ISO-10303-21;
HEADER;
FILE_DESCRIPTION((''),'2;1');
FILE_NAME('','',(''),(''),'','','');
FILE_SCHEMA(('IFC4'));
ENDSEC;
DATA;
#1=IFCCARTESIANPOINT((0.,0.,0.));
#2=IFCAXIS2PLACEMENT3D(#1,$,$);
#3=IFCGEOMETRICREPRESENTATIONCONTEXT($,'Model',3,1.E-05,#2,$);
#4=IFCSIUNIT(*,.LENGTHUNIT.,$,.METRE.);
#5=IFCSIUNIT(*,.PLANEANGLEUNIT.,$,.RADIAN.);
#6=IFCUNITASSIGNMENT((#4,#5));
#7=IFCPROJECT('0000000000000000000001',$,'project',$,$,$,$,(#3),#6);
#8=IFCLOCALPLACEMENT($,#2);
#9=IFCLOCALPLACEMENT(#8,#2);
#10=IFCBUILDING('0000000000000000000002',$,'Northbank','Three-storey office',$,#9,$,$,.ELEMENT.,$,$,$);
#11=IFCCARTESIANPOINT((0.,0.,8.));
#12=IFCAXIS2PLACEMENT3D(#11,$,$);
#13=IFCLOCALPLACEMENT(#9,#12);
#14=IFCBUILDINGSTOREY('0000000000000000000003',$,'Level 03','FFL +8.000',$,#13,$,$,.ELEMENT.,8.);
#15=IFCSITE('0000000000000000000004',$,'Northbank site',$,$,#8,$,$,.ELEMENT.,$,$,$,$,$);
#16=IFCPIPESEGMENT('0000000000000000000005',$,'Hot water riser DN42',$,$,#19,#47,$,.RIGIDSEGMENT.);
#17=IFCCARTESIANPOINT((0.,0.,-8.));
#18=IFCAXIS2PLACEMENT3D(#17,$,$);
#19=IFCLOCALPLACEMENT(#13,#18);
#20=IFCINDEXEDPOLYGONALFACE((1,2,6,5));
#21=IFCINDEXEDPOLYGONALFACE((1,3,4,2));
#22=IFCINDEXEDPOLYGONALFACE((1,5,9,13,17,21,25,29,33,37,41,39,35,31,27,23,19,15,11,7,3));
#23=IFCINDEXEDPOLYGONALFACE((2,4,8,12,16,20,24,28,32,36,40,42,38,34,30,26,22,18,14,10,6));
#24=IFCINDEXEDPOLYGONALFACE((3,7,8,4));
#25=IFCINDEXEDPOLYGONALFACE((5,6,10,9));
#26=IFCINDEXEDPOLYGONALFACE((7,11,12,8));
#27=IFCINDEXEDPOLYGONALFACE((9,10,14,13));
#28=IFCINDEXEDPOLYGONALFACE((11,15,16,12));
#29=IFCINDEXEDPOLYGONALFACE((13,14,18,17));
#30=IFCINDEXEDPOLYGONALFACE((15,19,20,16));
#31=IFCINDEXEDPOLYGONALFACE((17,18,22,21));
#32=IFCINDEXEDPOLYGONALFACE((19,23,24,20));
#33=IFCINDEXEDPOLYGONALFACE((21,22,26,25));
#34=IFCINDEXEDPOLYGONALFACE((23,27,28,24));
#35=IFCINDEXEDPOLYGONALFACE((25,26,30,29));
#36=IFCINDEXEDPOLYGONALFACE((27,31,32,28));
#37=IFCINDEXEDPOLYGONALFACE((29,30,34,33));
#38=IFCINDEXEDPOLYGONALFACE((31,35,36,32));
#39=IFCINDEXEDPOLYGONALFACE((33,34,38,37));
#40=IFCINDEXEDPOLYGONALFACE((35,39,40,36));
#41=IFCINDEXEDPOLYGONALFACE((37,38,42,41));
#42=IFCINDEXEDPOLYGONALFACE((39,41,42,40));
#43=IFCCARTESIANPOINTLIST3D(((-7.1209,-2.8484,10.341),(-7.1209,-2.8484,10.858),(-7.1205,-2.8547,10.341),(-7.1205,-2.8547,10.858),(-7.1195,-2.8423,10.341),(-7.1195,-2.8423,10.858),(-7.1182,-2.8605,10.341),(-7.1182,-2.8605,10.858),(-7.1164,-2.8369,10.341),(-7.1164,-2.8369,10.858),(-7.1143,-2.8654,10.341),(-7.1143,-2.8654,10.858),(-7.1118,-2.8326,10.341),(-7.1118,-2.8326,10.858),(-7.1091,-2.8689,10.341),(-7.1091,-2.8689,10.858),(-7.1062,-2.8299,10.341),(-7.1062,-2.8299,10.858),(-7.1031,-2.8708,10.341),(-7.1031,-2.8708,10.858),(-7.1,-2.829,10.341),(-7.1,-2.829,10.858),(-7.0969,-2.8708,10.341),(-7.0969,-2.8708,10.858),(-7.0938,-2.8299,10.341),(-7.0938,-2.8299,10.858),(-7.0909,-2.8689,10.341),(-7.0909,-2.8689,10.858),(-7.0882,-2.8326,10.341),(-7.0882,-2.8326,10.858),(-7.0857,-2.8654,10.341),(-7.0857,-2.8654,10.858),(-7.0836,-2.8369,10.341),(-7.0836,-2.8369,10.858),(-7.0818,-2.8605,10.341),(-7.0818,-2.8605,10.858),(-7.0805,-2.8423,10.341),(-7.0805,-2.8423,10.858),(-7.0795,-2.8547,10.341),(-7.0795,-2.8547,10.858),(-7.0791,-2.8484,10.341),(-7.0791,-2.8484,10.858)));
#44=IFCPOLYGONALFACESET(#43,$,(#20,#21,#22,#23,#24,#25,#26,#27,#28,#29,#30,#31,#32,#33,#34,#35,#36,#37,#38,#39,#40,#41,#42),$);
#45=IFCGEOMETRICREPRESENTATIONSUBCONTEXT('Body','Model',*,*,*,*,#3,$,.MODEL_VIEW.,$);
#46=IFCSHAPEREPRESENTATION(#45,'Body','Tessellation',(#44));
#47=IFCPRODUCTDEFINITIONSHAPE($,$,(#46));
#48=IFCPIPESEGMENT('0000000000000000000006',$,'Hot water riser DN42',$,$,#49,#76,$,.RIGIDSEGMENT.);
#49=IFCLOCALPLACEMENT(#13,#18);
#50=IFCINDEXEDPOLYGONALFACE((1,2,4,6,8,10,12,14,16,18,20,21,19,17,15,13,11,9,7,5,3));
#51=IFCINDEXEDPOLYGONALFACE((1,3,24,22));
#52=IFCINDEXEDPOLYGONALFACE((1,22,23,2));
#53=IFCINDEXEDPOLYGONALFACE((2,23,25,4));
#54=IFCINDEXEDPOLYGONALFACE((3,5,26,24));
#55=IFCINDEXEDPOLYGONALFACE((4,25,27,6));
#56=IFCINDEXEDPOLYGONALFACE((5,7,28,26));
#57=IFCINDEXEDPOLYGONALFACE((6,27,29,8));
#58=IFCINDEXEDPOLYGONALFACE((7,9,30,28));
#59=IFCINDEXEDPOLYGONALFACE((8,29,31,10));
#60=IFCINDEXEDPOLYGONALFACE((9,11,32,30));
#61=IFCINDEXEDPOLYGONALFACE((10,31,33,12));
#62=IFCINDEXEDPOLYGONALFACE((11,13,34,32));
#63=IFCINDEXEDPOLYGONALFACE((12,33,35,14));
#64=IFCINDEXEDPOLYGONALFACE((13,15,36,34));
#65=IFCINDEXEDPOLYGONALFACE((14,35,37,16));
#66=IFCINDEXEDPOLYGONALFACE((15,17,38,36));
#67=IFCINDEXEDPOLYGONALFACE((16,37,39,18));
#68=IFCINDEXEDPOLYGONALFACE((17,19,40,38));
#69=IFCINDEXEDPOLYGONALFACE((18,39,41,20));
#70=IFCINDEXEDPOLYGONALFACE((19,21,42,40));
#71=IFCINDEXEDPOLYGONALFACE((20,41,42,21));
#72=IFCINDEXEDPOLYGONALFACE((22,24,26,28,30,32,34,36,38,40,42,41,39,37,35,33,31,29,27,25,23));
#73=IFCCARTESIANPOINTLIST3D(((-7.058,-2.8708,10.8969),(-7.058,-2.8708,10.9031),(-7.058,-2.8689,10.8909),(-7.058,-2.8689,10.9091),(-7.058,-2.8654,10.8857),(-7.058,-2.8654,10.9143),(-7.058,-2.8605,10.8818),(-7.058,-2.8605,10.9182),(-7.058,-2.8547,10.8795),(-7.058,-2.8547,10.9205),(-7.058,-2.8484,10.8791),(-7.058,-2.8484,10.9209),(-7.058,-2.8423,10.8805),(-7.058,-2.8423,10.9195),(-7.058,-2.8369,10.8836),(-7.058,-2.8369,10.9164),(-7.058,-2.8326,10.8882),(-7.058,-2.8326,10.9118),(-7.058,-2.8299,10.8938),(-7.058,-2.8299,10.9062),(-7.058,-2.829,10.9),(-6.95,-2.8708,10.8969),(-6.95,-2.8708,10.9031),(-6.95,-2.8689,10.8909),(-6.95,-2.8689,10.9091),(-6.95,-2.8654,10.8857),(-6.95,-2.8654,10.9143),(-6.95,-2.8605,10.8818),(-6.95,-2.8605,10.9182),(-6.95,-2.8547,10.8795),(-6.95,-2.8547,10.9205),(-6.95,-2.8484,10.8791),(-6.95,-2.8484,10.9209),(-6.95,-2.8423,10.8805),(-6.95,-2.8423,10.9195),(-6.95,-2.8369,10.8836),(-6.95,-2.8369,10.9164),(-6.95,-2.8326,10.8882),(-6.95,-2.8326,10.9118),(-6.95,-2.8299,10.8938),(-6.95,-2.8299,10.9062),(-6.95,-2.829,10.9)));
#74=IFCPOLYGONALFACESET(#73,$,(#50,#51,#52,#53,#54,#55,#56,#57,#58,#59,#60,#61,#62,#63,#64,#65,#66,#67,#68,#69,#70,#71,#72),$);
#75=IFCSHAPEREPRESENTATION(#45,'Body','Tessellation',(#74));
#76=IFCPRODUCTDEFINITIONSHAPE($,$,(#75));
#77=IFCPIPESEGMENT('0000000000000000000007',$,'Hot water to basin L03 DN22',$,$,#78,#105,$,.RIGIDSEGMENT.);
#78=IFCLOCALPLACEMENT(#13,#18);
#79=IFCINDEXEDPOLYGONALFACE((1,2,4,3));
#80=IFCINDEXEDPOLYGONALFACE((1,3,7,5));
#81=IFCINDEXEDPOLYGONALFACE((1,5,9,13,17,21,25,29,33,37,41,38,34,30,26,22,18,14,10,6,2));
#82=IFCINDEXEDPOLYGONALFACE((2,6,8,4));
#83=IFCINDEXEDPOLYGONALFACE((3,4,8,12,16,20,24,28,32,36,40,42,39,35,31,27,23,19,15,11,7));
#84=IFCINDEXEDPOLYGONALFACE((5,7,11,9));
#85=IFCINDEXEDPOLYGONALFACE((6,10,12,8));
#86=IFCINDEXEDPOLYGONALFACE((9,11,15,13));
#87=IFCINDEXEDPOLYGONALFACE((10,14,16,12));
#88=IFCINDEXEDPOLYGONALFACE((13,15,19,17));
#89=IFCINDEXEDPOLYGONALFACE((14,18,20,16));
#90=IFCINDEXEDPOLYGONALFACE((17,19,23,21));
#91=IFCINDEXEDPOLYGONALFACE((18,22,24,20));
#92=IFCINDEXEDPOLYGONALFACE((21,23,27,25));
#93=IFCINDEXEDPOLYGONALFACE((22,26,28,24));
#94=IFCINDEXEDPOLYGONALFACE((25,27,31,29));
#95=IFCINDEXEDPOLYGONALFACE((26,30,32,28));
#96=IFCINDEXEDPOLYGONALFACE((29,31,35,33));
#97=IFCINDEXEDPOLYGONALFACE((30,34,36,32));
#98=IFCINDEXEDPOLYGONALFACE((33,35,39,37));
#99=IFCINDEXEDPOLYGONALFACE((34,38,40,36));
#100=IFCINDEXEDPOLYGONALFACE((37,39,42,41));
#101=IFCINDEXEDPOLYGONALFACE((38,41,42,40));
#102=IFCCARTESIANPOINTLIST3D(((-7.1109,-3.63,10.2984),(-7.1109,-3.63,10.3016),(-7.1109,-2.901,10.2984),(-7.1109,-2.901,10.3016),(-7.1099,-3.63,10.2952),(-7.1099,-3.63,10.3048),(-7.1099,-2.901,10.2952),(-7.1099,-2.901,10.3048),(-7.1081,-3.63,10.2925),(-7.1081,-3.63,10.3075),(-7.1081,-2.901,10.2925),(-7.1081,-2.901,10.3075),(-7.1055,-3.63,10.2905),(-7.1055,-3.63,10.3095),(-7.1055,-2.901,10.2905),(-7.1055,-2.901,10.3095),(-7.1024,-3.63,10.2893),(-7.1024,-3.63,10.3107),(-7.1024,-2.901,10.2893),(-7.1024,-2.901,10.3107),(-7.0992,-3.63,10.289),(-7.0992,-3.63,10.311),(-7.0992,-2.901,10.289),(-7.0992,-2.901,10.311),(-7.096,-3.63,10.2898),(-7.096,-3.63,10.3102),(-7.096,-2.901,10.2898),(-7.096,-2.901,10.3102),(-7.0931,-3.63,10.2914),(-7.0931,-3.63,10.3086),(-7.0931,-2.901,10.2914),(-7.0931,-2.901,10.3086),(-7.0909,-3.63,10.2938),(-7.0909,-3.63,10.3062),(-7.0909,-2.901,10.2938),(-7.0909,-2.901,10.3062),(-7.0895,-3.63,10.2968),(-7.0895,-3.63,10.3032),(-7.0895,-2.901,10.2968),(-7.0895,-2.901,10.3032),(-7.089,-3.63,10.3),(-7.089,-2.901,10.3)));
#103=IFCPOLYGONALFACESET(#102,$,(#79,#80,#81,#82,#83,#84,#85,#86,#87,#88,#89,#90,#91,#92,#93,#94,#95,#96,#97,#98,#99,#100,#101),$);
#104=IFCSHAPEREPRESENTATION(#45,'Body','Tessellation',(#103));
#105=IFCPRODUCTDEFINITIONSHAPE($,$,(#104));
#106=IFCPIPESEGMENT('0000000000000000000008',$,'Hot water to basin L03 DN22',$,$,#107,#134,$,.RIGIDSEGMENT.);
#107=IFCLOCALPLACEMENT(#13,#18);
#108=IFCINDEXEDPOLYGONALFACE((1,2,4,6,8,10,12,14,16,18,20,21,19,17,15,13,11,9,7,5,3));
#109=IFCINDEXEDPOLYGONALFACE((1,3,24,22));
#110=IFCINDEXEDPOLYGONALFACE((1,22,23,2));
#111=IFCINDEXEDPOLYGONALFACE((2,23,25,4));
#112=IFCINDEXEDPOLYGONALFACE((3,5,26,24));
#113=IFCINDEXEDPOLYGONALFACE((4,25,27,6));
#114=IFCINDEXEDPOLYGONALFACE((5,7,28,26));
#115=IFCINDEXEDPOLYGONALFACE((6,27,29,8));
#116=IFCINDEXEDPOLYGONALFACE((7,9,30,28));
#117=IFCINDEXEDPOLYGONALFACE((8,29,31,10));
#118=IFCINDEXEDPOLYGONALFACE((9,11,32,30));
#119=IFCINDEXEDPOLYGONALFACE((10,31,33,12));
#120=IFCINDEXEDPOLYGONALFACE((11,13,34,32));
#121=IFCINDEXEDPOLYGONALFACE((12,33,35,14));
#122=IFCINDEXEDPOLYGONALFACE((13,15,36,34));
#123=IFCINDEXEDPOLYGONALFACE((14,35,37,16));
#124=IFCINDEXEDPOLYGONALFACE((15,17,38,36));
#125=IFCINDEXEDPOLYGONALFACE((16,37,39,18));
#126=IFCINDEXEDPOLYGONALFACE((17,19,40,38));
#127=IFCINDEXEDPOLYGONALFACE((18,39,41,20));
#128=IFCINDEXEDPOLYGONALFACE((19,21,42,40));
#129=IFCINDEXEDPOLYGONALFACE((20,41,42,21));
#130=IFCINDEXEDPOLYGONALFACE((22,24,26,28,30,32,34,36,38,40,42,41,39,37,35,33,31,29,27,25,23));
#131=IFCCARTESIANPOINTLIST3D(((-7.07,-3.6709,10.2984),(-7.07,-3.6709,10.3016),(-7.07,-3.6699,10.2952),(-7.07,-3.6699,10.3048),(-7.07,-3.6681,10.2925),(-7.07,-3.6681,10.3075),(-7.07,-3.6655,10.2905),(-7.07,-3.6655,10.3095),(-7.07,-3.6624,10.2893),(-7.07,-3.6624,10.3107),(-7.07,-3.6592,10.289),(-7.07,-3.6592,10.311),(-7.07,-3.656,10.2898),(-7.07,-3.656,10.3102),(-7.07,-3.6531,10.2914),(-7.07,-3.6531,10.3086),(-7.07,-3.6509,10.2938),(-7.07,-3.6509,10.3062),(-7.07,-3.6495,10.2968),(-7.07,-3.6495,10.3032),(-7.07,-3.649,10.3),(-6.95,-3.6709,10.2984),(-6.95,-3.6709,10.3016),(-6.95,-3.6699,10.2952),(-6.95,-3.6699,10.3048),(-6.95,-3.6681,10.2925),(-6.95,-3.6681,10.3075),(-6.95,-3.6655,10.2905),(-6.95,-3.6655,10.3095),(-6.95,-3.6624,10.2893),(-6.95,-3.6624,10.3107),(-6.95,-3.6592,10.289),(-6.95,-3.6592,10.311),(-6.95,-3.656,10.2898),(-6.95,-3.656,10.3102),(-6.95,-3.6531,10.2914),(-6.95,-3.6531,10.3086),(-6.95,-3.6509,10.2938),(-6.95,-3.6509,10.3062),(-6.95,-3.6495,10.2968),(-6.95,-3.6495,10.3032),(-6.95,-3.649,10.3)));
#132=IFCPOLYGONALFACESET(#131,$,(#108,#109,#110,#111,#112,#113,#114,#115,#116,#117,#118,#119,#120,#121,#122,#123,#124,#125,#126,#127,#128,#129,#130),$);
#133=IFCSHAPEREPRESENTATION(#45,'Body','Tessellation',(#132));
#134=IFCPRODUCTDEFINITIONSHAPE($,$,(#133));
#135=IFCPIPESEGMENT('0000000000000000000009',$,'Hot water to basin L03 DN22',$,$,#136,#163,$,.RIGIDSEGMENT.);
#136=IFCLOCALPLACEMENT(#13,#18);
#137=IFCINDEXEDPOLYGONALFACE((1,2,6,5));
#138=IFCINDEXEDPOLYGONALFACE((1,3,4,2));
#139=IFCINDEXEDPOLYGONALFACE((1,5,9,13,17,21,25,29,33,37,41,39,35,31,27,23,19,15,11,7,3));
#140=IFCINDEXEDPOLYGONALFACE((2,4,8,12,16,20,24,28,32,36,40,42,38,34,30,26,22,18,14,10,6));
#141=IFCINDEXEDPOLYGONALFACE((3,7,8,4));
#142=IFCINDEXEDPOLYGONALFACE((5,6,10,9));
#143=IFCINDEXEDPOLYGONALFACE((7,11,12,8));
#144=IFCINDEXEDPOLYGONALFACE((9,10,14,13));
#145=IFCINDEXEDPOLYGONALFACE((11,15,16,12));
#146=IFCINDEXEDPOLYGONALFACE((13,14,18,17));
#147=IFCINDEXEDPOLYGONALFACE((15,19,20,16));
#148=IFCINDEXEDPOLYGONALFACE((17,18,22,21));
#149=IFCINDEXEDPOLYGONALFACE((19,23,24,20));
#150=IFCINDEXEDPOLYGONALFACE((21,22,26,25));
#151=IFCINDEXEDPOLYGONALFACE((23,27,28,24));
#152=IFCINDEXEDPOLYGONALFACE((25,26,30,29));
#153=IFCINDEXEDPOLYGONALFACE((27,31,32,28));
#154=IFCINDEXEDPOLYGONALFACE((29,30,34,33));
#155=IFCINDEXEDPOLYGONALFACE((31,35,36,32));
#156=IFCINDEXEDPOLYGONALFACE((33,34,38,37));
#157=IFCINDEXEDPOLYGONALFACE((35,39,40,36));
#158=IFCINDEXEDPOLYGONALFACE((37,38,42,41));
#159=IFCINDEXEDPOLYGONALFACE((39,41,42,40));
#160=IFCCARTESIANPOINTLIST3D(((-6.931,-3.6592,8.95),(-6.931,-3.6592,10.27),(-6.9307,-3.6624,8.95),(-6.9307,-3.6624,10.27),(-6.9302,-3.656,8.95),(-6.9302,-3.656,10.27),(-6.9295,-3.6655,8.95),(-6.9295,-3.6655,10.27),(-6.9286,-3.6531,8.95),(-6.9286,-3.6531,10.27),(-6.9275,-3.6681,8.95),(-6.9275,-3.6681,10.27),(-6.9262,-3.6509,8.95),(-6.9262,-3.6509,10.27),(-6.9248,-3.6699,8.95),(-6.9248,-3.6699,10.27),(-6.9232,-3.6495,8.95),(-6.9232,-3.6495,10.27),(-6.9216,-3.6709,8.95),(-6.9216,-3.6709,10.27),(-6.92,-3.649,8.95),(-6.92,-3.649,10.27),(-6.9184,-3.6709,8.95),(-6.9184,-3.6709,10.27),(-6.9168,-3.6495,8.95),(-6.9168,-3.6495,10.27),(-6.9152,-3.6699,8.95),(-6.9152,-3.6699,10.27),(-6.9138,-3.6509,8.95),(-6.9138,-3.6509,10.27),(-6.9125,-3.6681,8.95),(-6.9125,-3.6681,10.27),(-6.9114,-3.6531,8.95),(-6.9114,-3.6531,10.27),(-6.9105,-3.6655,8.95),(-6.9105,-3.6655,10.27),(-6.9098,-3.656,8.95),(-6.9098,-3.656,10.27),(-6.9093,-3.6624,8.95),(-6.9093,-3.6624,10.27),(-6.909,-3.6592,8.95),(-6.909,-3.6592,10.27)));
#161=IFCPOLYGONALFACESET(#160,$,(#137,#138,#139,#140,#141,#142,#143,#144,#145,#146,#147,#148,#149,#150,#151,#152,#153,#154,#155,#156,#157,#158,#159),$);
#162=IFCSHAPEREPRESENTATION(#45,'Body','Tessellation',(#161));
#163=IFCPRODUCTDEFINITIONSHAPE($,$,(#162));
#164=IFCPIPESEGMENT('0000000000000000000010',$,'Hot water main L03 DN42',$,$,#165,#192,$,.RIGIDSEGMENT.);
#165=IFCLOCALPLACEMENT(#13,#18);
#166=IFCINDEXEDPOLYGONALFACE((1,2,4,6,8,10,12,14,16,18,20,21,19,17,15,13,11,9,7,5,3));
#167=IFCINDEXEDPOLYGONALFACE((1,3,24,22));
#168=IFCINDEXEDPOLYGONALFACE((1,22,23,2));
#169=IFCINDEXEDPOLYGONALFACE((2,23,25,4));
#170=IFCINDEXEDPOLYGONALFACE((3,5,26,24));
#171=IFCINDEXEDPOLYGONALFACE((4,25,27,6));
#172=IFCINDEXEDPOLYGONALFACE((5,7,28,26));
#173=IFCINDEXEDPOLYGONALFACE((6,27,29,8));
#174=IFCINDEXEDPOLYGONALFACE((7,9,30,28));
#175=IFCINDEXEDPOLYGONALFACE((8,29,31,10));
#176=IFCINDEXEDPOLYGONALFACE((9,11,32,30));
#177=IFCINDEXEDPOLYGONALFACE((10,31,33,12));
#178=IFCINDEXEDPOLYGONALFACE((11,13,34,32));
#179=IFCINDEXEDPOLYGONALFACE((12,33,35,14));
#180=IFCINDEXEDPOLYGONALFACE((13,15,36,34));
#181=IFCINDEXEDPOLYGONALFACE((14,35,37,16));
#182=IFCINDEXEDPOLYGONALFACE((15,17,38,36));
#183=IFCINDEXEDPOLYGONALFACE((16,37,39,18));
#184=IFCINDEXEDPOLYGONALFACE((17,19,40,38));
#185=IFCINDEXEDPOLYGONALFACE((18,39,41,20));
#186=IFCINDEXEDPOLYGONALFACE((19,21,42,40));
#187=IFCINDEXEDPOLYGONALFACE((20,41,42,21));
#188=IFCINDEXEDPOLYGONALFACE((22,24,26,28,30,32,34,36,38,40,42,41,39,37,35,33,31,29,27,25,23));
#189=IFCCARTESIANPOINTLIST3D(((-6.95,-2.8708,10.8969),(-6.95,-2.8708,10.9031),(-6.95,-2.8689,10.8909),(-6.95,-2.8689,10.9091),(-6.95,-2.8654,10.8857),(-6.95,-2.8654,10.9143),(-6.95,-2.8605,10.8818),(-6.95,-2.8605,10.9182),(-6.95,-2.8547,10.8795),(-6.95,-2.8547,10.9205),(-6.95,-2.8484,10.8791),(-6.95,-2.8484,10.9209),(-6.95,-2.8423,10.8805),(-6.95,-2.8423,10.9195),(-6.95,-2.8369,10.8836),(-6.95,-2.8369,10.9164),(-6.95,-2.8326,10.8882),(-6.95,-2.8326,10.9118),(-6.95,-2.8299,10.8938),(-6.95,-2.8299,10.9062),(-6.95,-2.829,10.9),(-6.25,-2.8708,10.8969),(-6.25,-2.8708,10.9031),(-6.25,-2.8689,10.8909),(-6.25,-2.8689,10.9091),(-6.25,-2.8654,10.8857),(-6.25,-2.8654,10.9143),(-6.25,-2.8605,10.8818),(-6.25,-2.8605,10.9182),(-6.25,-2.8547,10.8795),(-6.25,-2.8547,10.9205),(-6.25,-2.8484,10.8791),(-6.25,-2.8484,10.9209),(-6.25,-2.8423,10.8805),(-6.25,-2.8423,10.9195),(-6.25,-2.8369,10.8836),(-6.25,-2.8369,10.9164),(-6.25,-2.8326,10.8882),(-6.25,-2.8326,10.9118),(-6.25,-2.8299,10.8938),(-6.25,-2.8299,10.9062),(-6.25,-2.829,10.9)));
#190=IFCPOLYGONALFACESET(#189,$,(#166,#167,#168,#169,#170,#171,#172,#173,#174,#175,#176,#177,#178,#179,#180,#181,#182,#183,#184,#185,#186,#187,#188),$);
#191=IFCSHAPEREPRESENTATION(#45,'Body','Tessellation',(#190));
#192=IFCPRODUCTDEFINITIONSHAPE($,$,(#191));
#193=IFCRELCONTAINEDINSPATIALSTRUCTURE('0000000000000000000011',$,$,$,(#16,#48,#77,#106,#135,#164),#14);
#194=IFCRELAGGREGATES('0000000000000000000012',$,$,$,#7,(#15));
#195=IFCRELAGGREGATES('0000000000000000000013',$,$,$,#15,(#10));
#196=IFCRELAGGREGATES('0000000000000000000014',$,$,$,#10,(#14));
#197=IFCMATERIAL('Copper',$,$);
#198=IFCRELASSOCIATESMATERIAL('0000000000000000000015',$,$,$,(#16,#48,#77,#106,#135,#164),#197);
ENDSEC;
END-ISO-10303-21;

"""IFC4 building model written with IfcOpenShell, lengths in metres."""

from ifc_helpers import new_model, si_unit, frame, origin, place, context, subcontext, project, spatial, circle, extrude, material, element, save


model = new_model("IFC4")

# Units and contexts
model_context = context("Model", 3, precision=1e-05, world=origin())
body_context = subcontext(model_context, "Body", "Model", "MODEL_VIEW")
ifc_project = project(units=[si_unit("LENGTHUNIT", "METRE"), si_unit("PLANEANGLEUNIT", "RADIAN")], contexts=[model_context])

# Site, building, storey
site_placement = place(None, origin())
site = spatial("IfcSite", under=ifc_project, at=site_placement, Name="Northbank site", CompositionType="ELEMENT")
building_placement = place(site_placement, origin())
building = spatial("IfcBuilding", under=site, at=building_placement, Name="Northbank", Description="Three-storey office", CompositionType="ELEMENT")
storey_placement = place(building_placement, frame((0.0, 0.0, 8.0)))
storey = spatial("IfcBuildingStorey", under=building, at=storey_placement, Name="Level 03", Description="FFL +8.000", CompositionType="ELEMENT", Elevation=8.0)

# Shared definitions
ifc_material_1 = material(Name="Copper")

# Pipe segments
pipe_segment_1_placement = place(storey_placement, frame((0.0, 0.0, -8.0)))
element("IfcPipeSegment", 1, at=pipe_segment_1_placement, inside=storey, material=ifc_material_1, Name="Hot water riser DN42", PredefinedType="RIGIDSEGMENT", context=body_context, shape_type="SweptSolid", body=[
    extrude(circle(Radius=0.021), frame((-7.1, -2.85, 10.341), z_axis=(0.0, 0.0, 1.0), x_axis=(0.0, 1.0, 0.0)), (0.0, 0.0, 1.0), 0.517),
])
pipe_segment_2_placement = place(storey_placement, frame((0.0, 0.0, -8.0)))
element("IfcPipeSegment", 2, at=pipe_segment_2_placement, inside=storey, material=ifc_material_1, Name="Hot water riser DN42", PredefinedType="RIGIDSEGMENT", context=body_context, shape_type="SweptSolid", body=[
    extrude(circle(Radius=0.021), frame((-7.058, -2.85, 10.9), z_axis=(1.0, 0.0, 0.0), x_axis=(0.0, 1.0, 0.0)), (0.0, 0.0, 1.0), 0.108),
])
pipe_segment_3_placement = place(storey_placement, frame((0.0, 0.0, -8.0)))
element("IfcPipeSegment", 3, at=pipe_segment_3_placement, inside=storey, material=ifc_material_1, Name="Hot water to basin L03 DN22", PredefinedType="RIGIDSEGMENT", context=body_context, shape_type="SweptSolid", body=[
    extrude(circle(Radius=0.011), frame((-7.1, -2.901, 10.3), z_axis=(0.0, -1.0, 0.0), x_axis=(1.0, 0.0, 0.0)), (0.0, 0.0, 1.0), 0.729),
])
pipe_segment_4_placement = place(storey_placement, frame((0.0, 0.0, -8.0)))
element("IfcPipeSegment", 4, at=pipe_segment_4_placement, inside=storey, material=ifc_material_1, Name="Hot water to basin L03 DN22", PredefinedType="RIGIDSEGMENT", context=body_context, shape_type="SweptSolid", body=[
    extrude(circle(Radius=0.011), frame((-7.07, -3.66, 10.3), z_axis=(1.0, 0.0, 0.0), x_axis=(0.0, 1.0, 0.0)), (0.0, 0.0, 1.0), 0.12),
])
pipe_segment_5_placement = place(storey_placement, frame((0.0, 0.0, -8.0)))
element("IfcPipeSegment", 5, at=pipe_segment_5_placement, inside=storey, material=ifc_material_1, Name="Hot water to basin L03 DN22", PredefinedType="RIGIDSEGMENT", context=body_context, shape_type="SweptSolid", body=[
    extrude(circle(Radius=0.011), frame((-6.92, -3.66, 10.27), z_axis=(0.0, 0.0, -1.0), x_axis=(0.0, 1.0, 0.0)), (0.0, 0.0, 1.0), 1.32),
])
pipe_segment_6_placement = place(storey_placement, frame((0.0, 0.0, -8.0)))
element("IfcPipeSegment", 6, at=pipe_segment_6_placement, inside=storey, material=ifc_material_1, Name="Hot water main L03 DN42", PredefinedType="RIGIDSEGMENT", context=body_context, shape_type="SweptSolid", body=[
    extrude(circle(Radius=0.021), frame((-6.95, -2.85, 10.9), z_axis=(1.0, 0.0, 0.0), x_axis=(0.0, 1.0, 0.0)), (0.0, 0.0, 1.0), 0.7),
])

save(model, "model.ifc")
